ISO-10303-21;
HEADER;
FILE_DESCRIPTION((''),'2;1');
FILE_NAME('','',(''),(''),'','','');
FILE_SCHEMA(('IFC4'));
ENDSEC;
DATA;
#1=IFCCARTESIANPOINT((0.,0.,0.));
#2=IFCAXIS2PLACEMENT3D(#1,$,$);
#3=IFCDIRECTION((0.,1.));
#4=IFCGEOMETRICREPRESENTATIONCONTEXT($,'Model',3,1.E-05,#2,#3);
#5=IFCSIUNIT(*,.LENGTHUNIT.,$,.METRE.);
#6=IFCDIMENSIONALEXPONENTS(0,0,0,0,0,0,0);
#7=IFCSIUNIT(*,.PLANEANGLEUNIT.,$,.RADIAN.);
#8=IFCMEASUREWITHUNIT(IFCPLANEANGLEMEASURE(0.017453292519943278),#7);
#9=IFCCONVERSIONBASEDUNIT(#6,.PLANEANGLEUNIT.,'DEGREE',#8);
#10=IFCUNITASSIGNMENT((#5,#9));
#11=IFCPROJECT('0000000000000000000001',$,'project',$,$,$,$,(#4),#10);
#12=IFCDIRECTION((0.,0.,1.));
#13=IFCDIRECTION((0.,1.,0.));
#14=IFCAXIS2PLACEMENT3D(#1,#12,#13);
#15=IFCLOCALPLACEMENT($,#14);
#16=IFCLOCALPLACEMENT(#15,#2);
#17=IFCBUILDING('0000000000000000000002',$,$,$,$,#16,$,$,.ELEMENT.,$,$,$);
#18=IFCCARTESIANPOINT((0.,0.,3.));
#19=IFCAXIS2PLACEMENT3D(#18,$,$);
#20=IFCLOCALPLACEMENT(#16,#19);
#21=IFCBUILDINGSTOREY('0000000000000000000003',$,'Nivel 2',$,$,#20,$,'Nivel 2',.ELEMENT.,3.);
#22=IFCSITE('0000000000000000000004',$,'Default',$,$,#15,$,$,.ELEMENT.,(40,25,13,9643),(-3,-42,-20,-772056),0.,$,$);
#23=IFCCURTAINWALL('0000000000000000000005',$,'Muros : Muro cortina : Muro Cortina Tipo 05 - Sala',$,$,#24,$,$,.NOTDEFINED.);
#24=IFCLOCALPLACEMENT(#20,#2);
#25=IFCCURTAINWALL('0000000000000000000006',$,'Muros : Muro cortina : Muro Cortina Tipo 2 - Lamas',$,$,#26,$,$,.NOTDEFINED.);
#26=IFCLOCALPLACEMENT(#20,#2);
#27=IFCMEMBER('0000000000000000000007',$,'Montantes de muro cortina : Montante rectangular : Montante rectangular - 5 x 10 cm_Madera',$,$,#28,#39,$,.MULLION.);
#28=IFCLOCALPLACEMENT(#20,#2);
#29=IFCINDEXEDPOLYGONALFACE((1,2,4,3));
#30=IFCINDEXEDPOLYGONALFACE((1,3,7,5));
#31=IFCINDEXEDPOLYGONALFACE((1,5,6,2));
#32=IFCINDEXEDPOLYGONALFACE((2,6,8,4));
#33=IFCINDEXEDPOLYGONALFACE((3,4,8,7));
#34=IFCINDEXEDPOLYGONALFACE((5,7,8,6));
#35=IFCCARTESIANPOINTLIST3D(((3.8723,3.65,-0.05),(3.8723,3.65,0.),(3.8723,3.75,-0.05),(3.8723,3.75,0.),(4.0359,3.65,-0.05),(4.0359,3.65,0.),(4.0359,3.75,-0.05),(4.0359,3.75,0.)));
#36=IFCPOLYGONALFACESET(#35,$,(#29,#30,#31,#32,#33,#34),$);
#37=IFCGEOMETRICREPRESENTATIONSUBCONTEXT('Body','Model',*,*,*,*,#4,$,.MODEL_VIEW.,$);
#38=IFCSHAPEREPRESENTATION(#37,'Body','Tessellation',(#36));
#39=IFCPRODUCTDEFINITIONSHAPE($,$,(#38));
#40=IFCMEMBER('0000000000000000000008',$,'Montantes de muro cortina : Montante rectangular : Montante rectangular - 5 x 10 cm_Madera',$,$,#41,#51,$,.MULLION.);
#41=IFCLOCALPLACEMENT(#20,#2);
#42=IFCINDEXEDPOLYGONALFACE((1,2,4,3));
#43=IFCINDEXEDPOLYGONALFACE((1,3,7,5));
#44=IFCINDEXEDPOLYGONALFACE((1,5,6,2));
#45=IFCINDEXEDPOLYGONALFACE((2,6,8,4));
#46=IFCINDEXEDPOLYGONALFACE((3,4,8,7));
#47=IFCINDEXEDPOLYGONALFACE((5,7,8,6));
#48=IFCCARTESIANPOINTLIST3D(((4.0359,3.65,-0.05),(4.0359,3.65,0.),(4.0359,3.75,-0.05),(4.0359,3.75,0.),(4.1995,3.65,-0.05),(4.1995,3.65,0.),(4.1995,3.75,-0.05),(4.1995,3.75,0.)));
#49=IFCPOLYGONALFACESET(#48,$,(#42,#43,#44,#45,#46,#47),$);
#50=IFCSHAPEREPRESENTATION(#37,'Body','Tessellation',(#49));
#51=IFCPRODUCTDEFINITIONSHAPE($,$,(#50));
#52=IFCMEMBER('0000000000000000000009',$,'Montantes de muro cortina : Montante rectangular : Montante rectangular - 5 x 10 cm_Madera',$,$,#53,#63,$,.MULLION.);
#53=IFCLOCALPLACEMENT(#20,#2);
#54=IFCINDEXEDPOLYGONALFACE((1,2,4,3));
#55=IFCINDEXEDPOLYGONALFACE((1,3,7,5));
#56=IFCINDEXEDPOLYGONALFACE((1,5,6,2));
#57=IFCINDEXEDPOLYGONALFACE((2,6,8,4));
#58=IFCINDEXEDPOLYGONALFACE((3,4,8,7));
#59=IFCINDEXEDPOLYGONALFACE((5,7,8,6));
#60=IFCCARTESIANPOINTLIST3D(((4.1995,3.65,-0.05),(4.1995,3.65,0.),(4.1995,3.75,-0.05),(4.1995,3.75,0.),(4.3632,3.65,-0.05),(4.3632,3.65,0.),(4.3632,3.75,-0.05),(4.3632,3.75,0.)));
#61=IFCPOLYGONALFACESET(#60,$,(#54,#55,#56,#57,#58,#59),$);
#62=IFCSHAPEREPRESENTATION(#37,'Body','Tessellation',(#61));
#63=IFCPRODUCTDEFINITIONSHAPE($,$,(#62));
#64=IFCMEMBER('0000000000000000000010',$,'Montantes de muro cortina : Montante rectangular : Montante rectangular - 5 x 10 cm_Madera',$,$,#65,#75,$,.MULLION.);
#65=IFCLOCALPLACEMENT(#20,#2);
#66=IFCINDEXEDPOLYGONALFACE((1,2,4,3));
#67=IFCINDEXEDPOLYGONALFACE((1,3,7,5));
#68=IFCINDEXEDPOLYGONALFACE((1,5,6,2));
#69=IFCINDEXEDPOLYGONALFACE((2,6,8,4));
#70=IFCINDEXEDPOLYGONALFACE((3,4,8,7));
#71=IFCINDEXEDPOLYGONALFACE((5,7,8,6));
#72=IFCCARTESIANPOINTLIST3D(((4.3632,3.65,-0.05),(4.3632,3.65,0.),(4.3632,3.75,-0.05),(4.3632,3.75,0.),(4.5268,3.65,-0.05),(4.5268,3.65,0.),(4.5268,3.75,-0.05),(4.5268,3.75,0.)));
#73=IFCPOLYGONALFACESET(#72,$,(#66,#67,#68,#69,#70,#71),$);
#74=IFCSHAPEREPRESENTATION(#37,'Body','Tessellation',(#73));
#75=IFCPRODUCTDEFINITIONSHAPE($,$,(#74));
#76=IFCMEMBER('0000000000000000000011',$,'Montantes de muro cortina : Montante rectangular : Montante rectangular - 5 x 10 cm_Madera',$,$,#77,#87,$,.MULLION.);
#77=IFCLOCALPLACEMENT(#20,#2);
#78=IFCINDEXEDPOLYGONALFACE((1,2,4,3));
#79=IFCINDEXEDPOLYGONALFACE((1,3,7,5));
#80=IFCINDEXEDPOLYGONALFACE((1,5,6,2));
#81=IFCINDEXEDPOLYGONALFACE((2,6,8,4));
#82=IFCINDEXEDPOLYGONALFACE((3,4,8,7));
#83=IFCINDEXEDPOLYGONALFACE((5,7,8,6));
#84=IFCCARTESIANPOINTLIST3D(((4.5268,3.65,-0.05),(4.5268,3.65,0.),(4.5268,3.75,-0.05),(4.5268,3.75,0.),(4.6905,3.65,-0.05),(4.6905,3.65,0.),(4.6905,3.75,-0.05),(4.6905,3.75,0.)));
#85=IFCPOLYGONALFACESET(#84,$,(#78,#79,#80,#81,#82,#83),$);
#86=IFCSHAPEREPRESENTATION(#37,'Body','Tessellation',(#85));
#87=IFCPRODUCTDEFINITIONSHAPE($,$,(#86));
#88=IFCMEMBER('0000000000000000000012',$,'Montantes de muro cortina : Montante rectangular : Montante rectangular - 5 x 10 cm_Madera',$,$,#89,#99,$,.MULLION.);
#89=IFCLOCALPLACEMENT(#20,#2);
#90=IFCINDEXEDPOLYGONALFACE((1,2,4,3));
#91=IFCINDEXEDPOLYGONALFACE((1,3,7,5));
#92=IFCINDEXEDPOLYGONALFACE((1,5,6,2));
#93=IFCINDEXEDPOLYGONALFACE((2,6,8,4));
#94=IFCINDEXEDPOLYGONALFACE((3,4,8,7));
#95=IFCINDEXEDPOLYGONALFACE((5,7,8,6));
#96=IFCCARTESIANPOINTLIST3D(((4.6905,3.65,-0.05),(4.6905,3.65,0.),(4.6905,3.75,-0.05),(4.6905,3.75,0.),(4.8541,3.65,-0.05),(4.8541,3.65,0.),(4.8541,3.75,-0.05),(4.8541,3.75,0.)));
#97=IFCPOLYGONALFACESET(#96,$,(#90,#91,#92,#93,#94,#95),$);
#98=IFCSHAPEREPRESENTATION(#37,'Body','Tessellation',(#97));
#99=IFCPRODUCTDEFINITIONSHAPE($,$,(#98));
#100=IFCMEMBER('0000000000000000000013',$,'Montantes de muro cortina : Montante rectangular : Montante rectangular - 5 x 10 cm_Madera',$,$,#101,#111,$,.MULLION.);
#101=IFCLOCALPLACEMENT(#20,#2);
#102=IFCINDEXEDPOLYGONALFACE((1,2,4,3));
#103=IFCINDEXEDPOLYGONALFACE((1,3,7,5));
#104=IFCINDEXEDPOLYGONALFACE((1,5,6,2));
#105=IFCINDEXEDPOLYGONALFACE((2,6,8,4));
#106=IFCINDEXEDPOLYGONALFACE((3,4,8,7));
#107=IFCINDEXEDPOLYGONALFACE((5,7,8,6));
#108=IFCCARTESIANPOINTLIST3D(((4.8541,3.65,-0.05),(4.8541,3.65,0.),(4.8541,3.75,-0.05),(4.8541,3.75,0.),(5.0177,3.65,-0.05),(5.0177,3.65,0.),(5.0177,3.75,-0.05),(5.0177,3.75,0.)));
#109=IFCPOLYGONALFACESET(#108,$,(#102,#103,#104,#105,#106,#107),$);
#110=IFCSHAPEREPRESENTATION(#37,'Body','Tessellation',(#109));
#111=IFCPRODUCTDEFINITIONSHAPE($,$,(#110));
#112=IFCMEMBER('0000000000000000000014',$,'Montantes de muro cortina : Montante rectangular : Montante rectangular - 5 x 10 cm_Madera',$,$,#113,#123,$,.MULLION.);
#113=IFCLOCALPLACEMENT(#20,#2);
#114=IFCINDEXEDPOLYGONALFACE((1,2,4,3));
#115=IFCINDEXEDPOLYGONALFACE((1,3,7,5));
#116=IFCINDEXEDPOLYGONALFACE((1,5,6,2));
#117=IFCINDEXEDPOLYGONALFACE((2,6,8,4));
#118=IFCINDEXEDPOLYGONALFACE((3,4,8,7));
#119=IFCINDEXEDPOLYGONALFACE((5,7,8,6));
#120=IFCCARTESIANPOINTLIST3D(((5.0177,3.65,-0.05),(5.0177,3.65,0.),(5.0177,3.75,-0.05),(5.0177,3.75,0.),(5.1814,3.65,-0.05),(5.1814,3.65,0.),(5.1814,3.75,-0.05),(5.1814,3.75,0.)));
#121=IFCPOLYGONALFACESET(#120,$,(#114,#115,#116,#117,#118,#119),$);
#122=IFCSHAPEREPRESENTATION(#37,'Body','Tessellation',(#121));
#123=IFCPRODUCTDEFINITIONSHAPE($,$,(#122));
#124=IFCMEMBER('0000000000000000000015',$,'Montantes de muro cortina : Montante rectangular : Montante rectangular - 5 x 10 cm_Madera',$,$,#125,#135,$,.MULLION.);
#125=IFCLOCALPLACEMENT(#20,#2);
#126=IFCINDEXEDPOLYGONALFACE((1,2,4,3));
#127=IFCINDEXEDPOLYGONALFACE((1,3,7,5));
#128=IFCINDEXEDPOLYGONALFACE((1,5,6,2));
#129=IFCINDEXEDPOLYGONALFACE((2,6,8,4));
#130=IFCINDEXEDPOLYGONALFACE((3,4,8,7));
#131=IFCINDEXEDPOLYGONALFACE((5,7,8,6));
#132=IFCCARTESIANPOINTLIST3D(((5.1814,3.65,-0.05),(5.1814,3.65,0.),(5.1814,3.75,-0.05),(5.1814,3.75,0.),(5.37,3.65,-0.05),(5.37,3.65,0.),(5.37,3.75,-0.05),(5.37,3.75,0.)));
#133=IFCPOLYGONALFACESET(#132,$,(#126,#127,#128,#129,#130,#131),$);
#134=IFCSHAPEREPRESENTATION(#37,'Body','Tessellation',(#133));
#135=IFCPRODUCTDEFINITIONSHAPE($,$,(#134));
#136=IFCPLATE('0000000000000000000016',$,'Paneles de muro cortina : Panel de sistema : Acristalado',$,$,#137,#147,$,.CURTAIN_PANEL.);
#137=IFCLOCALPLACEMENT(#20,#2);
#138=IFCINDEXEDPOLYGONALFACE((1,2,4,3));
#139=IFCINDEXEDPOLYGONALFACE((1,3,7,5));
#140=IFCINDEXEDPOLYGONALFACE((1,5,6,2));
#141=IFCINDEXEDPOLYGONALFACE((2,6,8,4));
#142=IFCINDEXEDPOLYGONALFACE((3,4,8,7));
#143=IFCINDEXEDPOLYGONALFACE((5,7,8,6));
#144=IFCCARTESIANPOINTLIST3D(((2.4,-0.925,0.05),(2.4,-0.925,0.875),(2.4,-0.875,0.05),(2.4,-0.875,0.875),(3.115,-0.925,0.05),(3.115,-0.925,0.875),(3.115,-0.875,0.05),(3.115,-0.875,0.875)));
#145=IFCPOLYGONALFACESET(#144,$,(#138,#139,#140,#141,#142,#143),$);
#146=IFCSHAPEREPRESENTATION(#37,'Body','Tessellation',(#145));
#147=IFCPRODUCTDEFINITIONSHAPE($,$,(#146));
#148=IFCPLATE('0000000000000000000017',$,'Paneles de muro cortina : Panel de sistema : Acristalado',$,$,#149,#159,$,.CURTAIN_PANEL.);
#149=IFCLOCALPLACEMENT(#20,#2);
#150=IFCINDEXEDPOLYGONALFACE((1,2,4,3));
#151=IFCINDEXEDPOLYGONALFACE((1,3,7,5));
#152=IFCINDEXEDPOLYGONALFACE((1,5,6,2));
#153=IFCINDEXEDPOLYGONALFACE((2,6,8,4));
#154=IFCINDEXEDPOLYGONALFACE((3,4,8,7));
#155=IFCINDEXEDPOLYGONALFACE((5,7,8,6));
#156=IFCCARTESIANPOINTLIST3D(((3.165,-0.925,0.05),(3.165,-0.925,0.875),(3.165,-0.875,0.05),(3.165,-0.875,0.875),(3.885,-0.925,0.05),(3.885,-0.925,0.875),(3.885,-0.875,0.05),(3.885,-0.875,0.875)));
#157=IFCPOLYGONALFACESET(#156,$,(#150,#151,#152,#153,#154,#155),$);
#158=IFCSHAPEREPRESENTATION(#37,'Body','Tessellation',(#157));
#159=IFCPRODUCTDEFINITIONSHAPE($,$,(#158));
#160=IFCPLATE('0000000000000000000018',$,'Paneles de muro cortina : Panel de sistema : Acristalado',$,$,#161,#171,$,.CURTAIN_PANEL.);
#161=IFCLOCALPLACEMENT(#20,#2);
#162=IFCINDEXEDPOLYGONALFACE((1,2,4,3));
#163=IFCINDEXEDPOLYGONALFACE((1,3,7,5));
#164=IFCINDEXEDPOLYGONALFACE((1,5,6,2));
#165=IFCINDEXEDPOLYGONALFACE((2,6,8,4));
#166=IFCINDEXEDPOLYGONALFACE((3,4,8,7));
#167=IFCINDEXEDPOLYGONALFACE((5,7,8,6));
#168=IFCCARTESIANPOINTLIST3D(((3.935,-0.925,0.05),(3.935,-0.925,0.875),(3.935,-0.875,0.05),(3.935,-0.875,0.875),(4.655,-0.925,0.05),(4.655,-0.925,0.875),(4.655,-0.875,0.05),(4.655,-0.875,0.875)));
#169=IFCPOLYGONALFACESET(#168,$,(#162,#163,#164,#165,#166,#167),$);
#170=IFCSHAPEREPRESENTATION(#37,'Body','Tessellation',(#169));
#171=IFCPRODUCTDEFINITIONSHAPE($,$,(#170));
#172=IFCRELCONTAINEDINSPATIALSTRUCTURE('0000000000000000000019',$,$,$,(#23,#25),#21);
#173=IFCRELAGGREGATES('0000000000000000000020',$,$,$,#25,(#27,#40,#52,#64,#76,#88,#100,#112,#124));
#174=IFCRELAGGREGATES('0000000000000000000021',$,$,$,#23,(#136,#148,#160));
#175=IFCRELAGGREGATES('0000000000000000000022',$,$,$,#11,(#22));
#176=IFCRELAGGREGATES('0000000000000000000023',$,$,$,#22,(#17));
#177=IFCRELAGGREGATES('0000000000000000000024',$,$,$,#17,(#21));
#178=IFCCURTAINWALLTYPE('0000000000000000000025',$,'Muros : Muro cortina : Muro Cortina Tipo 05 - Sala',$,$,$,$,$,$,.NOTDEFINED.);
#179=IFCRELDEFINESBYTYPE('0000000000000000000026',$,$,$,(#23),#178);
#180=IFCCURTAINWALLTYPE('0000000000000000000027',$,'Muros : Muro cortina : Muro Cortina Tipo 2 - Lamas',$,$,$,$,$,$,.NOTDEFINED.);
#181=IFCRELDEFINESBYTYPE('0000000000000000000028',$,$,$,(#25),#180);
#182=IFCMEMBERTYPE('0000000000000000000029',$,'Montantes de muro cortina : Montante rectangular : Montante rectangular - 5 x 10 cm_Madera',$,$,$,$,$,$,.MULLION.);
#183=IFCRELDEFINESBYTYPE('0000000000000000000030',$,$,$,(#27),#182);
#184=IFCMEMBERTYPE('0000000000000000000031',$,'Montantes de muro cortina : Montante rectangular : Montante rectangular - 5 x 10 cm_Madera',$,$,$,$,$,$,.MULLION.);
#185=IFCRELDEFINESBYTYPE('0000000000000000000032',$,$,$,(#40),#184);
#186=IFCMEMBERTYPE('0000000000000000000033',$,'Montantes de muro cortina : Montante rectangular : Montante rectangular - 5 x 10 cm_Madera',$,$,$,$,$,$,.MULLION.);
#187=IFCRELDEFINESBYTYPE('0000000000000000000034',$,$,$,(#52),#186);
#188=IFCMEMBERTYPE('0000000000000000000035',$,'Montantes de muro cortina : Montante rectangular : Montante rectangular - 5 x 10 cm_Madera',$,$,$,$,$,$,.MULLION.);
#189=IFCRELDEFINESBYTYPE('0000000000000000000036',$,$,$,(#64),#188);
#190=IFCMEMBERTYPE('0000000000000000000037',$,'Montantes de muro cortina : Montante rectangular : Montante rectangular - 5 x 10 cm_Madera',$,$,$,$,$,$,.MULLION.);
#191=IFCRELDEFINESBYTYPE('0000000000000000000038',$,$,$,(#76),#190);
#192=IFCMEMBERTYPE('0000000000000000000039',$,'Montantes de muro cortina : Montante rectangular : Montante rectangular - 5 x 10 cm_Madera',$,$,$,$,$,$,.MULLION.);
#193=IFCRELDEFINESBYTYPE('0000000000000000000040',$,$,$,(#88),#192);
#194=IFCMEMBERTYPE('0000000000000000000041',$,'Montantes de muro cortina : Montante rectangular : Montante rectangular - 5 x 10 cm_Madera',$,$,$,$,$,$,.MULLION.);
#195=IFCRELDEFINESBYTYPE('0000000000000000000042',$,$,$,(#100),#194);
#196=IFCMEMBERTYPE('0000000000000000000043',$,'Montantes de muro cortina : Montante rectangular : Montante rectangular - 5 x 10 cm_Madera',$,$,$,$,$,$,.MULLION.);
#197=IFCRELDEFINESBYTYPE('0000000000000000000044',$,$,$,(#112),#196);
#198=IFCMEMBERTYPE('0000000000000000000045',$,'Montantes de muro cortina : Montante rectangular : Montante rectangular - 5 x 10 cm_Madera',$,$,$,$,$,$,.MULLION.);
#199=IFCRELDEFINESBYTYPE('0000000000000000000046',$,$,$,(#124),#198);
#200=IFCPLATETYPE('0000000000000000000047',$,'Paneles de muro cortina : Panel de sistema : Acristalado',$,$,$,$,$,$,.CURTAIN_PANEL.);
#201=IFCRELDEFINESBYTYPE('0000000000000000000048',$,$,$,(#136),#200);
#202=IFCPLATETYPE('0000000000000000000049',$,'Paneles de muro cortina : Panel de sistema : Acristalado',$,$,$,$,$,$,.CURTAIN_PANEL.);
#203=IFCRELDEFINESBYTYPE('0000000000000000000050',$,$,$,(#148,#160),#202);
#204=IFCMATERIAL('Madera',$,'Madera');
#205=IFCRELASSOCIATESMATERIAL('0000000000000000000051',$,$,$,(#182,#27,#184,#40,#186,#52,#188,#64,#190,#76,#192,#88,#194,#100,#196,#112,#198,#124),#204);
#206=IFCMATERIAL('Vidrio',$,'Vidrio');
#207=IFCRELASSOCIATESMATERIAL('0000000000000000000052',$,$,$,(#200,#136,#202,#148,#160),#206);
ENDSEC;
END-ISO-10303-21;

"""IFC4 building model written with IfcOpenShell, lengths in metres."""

from ifc_helpers import new_model, entity, si_unit, converted_unit, direction, frame, origin, place, context, subcontext, project, spatial, indexed_curve, outline, extrude, source, transform, mapped, material, type_object, type_shapes, element, aggregate, save


model = new_model("IFC4")

# Units and contexts
model_context = context("Model", 3, precision=1e-05, world=origin(), true_north=direction((0.0, 1.0)))
body_context = subcontext(model_context, "Body", "Model", "MODEL_VIEW")
ifc_project = project(units=[si_unit("LENGTHUNIT", "METRE"), converted_unit("PLANEANGLEUNIT", "DEGREE", entity("IfcPlaneAngleMeasure", 0.017453292519943278), si_unit("PLANEANGLEUNIT", "RADIAN"), dimensions=[0, 0, 0, 0, 0, 0, 0])], contexts=[model_context])

# Site, building, storey
site_placement = place(None, frame((0.0, 0.0, 0.0), z_axis=(0.0, 0.0, 1.0), x_axis=(0.0, 1.0, 0.0)))
site = spatial("IfcSite", under=ifc_project, at=site_placement, Name="Default", CompositionType="ELEMENT", RefLatitude=(40, 25, 13, 9643), RefLongitude=(-3, -42, -20, -772056), RefElevation=0.0)
building_placement = place(site_placement, origin())
building = spatial("IfcBuilding", under=site, at=building_placement, CompositionType="ELEMENT")
storey_placement = place(building_placement, frame((0.0, 0.0, 3.0)))
storey = spatial("IfcBuildingStorey", under=building, at=storey_placement, Name="Nivel 2", LongName="Nivel 2", CompositionType="ELEMENT", Elevation=3.0)

# Curtain walls, members
curtain_wall_type_1 = type_object("IfcCurtainWallType", Name="Muros : Muro cortina : Muro Cortina Tipo 05 - Sala", PredefinedType="NOTDEFINED")
curtain_wall_1_placement = place(storey_placement, frame((0.0, 0.0, -3.0)))
curtain_wall_1 = element("IfcCurtainWall", 1, at=curtain_wall_1_placement, inside=storey, type_object=curtain_wall_type_1, Name="Muros : Muro cortina : Muro Cortina Tipo 05 - Sala", PredefinedType="NOTDEFINED")
curtain_wall_type_2 = type_object("IfcCurtainWallType", Name="Muros : Muro cortina : Muro Cortina Tipo 2 - Lamas", PredefinedType="NOTDEFINED")
curtain_wall_2_placement = place(storey_placement, frame((0.0, 0.0, -3.0)))
curtain_wall_2 = element("IfcCurtainWall", 2, at=curtain_wall_2_placement, inside=storey, type_object=curtain_wall_type_2, Name="Muros : Muro cortina : Muro Cortina Tipo 2 - Lamas", PredefinedType="NOTDEFINED")
ifc_material_1 = material(Name="Madera", Category="Madera")
member_type_1 = type_object("IfcMemberType", Name="Montantes de muro cortina : Montante rectangular : Montante rectangular - 5 x 10 cm_Madera", PredefinedType="MULLION", material=ifc_material_1)
shared_shape_1 = source(origin(), body_context, "Body", "SweptSolid", [
    extrude(outline(indexed_curve([(-0.0818, -0.05), (0.0818, -0.05), (0.0818, 0.05), (-0.0818, 0.05), (-0.0818, -0.05)], self_intersect=False)), frame((3.9541, 3.7, 2.95), z_axis=(0.0, 0.0, 1.0), x_axis=(-1.0, 0.0, 0.0)), (0.0, 0.0, 1.0), 0.05),
])
type_shapes(member_type_1, [shared_shape_1])
member_1_placement = place(curtain_wall_2_placement, origin())
member_1 = element("IfcMember", 3, at=member_1_placement, type_object=member_type_1, material=ifc_material_1, Name="Montantes de muro cortina : Montante rectangular : Montante rectangular - 5 x 10 cm_Madera", PredefinedType="MULLION", context=body_context, shape_type="MappedRepresentation", body=[
    mapped(shared_shape_1, transform((0.0, 0.0, 0.0), scale=1.0)),
])
member_type_2 = type_object("IfcMemberType", Name="Montantes de muro cortina : Montante rectangular : Montante rectangular - 5 x 10 cm_Madera", PredefinedType="MULLION", material=ifc_material_1)
shared_shape_2 = source(origin(), body_context, "Body", "SweptSolid", [
    extrude(outline(indexed_curve([(-0.0818, -0.05), (0.0818, -0.05), (0.0818, 0.05), (-0.0818, 0.05), (-0.0818, -0.05)], self_intersect=False)), frame((4.1177, 3.7, 2.95), z_axis=(0.0, 0.0, 1.0), x_axis=(-1.0, 0.0, 0.0)), (0.0, 0.0, 1.0), 0.05),
])
type_shapes(member_type_2, [shared_shape_2])
member_2_placement = place(curtain_wall_2_placement, origin())
member_2 = element("IfcMember", 4, at=member_2_placement, type_object=member_type_2, material=ifc_material_1, Name="Montantes de muro cortina : Montante rectangular : Montante rectangular - 5 x 10 cm_Madera", PredefinedType="MULLION", context=body_context, shape_type="MappedRepresentation", body=[
    mapped(shared_shape_2, transform((0.0, 0.0, 0.0), scale=1.0)),
])
member_type_3 = type_object("IfcMemberType", Name="Montantes de muro cortina : Montante rectangular : Montante rectangular - 5 x 10 cm_Madera", PredefinedType="MULLION", material=ifc_material_1)
shared_shape_3 = source(origin(), body_context, "Body", "SweptSolid", [
    extrude(outline(indexed_curve([(-0.0818, -0.05), (0.0818, -0.05), (0.0818, 0.05), (-0.0818, 0.05), (-0.0818, -0.05)], self_intersect=False)), frame((4.2814, 3.7, 2.95), z_axis=(0.0, 0.0, 1.0), x_axis=(-1.0, 0.0, 0.0)), (0.0, 0.0, 1.0), 0.05),
])
type_shapes(member_type_3, [shared_shape_3])
member_3_placement = place(curtain_wall_2_placement, origin())
member_3 = element("IfcMember", 5, at=member_3_placement, type_object=member_type_3, material=ifc_material_1, Name="Montantes de muro cortina : Montante rectangular : Montante rectangular - 5 x 10 cm_Madera", PredefinedType="MULLION", context=body_context, shape_type="MappedRepresentation", body=[
    mapped(shared_shape_3, transform((0.0, 0.0, 0.0), scale=1.0)),
])
member_type_4 = type_object("IfcMemberType", Name="Montantes de muro cortina : Montante rectangular : Montante rectangular - 5 x 10 cm_Madera", PredefinedType="MULLION", material=ifc_material_1)
shared_shape_4 = source(origin(), body_context, "Body", "SweptSolid", [
    extrude(outline(indexed_curve([(-0.0818, -0.05), (0.0818, -0.05), (0.0818, 0.05), (-0.0818, 0.05), (-0.0818, -0.05)], self_intersect=False)), frame((4.445, 3.7, 2.95), z_axis=(0.0, 0.0, 1.0), x_axis=(-1.0, 0.0, 0.0)), (0.0, 0.0, 1.0), 0.05),
])
type_shapes(member_type_4, [shared_shape_4])
member_4_placement = place(curtain_wall_2_placement, origin())
member_4 = element("IfcMember", 6, at=member_4_placement, type_object=member_type_4, material=ifc_material_1, Name="Montantes de muro cortina : Montante rectangular : Montante rectangular - 5 x 10 cm_Madera", PredefinedType="MULLION", context=body_context, shape_type="MappedRepresentation", body=[
    mapped(shared_shape_4, transform((0.0, 0.0, 0.0), scale=1.0)),
])
member_type_5 = type_object("IfcMemberType", Name="Montantes de muro cortina : Montante rectangular : Montante rectangular - 5 x 10 cm_Madera", PredefinedType="MULLION", material=ifc_material_1)
shared_shape_5 = source(origin(), body_context, "Body", "SweptSolid", [
    extrude(outline(indexed_curve([(-0.0818, -0.05), (0.0818, -0.05), (0.0818, 0.05), (-0.0818, 0.05), (-0.0818, -0.05)], self_intersect=False)), frame((4.6086, 3.7, 2.95), z_axis=(0.0, 0.0, 1.0), x_axis=(-1.0, 0.0, 0.0)), (0.0, 0.0, 1.0), 0.05),
])
type_shapes(member_type_5, [shared_shape_5])
member_5_placement = place(curtain_wall_2_placement, origin())
member_5 = element("IfcMember", 7, at=member_5_placement, type_object=member_type_5, material=ifc_material_1, Name="Montantes de muro cortina : Montante rectangular : Montante rectangular - 5 x 10 cm_Madera", PredefinedType="MULLION", context=body_context, shape_type="MappedRepresentation", body=[
    mapped(shared_shape_5, transform((0.0, 0.0, 0.0), scale=1.0)),
])
member_type_6 = type_object("IfcMemberType", Name="Montantes de muro cortina : Montante rectangular : Montante rectangular - 5 x 10 cm_Madera", PredefinedType="MULLION", material=ifc_material_1)
shared_shape_6 = source(origin(), body_context, "Body", "SweptSolid", [
    extrude(outline(indexed_curve([(-0.0818, -0.05), (0.0818, -0.05), (0.0818, 0.05), (-0.0818, 0.05), (-0.0818, -0.05)], self_intersect=False)), frame((4.7723, 3.7, 2.95), z_axis=(0.0, 0.0, 1.0), x_axis=(-1.0, 0.0, 0.0)), (0.0, 0.0, 1.0), 0.05),
])
type_shapes(member_type_6, [shared_shape_6])
member_6_placement = place(curtain_wall_2_placement, origin())
member_6 = element("IfcMember", 8, at=member_6_placement, type_object=member_type_6, material=ifc_material_1, Name="Montantes de muro cortina : Montante rectangular : Montante rectangular - 5 x 10 cm_Madera", PredefinedType="MULLION", context=body_context, shape_type="MappedRepresentation", body=[
    mapped(shared_shape_6, transform((0.0, 0.0, 0.0), scale=1.0)),
])
member_type_7 = type_object("IfcMemberType", Name="Montantes de muro cortina : Montante rectangular : Montante rectangular - 5 x 10 cm_Madera", PredefinedType="MULLION", material=ifc_material_1)
shared_shape_7 = source(origin(), body_context, "Body", "SweptSolid", [
    extrude(outline(indexed_curve([(-0.0818, -0.05), (0.0818, -0.05), (0.0818, 0.05), (-0.0818, 0.05), (-0.0818, -0.05)], self_intersect=False)), frame((4.9359, 3.7, 2.95), z_axis=(0.0, 0.0, 1.0), x_axis=(-1.0, 0.0, 0.0)), (0.0, 0.0, 1.0), 0.05),
])
type_shapes(member_type_7, [shared_shape_7])
member_7_placement = place(curtain_wall_2_placement, origin())
member_7 = element("IfcMember", 9, at=member_7_placement, type_object=member_type_7, material=ifc_material_1, Name="Montantes de muro cortina : Montante rectangular : Montante rectangular - 5 x 10 cm_Madera", PredefinedType="MULLION", context=body_context, shape_type="MappedRepresentation", body=[
    mapped(shared_shape_7, transform((0.0, 0.0, 0.0), scale=1.0)),
])
member_type_8 = type_object("IfcMemberType", Name="Montantes de muro cortina : Montante rectangular : Montante rectangular - 5 x 10 cm_Madera", PredefinedType="MULLION", material=ifc_material_1)
shared_shape_8 = source(origin(), body_context, "Body", "SweptSolid", [
    extrude(outline(indexed_curve([(-0.0818, -0.05), (0.0818, -0.05), (0.0818, 0.05), (-0.0818, 0.05), (-0.0818, -0.05)], self_intersect=False)), frame((5.0995, 3.7, 2.95), z_axis=(0.0, 0.0, 1.0), x_axis=(-1.0, 0.0, 0.0)), (0.0, 0.0, 1.0), 0.05),
])
type_shapes(member_type_8, [shared_shape_8])
member_8_placement = place(curtain_wall_2_placement, origin())
member_8 = element("IfcMember", 10, at=member_8_placement, type_object=member_type_8, material=ifc_material_1, Name="Montantes de muro cortina : Montante rectangular : Montante rectangular - 5 x 10 cm_Madera", PredefinedType="MULLION", context=body_context, shape_type="MappedRepresentation", body=[
    mapped(shared_shape_8, transform((0.0, 0.0, 0.0), scale=1.0)),
])
member_type_9 = type_object("IfcMemberType", Name="Montantes de muro cortina : Montante rectangular : Montante rectangular - 5 x 10 cm_Madera", PredefinedType="MULLION", material=ifc_material_1)
shared_shape_9 = source(origin(), body_context, "Body", "SweptSolid", [
    extrude(outline(indexed_curve([(-0.0943, -0.05), (0.0943, -0.05), (0.0943, 0.05), (-0.0943, 0.05), (-0.0943, -0.05)], self_intersect=False)), frame((5.2757, 3.7, 2.95), z_axis=(0.0, 0.0, 1.0), x_axis=(-1.0, 0.0, 0.0)), (0.0, 0.0, 1.0), 0.05),
])
type_shapes(member_type_9, [shared_shape_9])
member_9_placement = place(curtain_wall_2_placement, origin())
member_9 = element("IfcMember", 11, at=member_9_placement, type_object=member_type_9, material=ifc_material_1, Name="Montantes de muro cortina : Montante rectangular : Montante rectangular - 5 x 10 cm_Madera", PredefinedType="MULLION", context=body_context, shape_type="MappedRepresentation", body=[
    mapped(shared_shape_9, transform((0.0, 0.0, 0.0), scale=1.0)),
])
aggregate(curtain_wall_2, [member_1, member_2, member_3, member_4, member_5, member_6, member_7, member_8, member_9])

# Plates
ifc_material_2 = material(Name="Vidrio", Category="Vidrio")
plate_type_1 = type_object("IfcPlateType", Name="Paneles de muro cortina : Panel de sistema : Acristalado", PredefinedType="CURTAIN_PANEL", material=ifc_material_2)
shared_shape_10 = source(origin(), body_context, "Body", "SweptSolid", [
    extrude(outline(indexed_curve([(-0.025, -0.3575), (0.025, -0.3575), (0.025, 0.3575), (-0.025, 0.3575), (-0.025, -0.3575)], self_intersect=False)), frame((0.0, 0.0, 0.0), z_axis=(0.0, 0.0, 1.0), x_axis=(0.0, 1.0, 0.0)), (0.0, 0.0, 1.0), 0.825),
])
type_shapes(plate_type_1, [shared_shape_10])
plate_1_placement = place(curtain_wall_1_placement, frame((2.7575, -0.9, 3.05)))
plate_1 = element("IfcPlate", 12, at=plate_1_placement, type_object=plate_type_1, material=ifc_material_2, Name="Paneles de muro cortina : Panel de sistema : Acristalado", PredefinedType="CURTAIN_PANEL", context=body_context, shape_type="MappedRepresentation", body=[
    mapped(shared_shape_10, transform((0.0, 0.0, 0.0), scale=1.0)),
])
plate_type_2 = type_object("IfcPlateType", Name="Paneles de muro cortina : Panel de sistema : Acristalado", PredefinedType="CURTAIN_PANEL", material=ifc_material_2)
shared_shape_11 = source(origin(), body_context, "Body", "SweptSolid", [
    extrude(outline(indexed_curve([(-0.025, -0.36), (0.025, -0.36), (0.025, 0.36), (-0.025, 0.36), (-0.025, -0.36)], self_intersect=False)), frame((0.0, 0.0, 0.0), z_axis=(0.0, 0.0, 1.0), x_axis=(0.0, 1.0, 0.0)), (0.0, 0.0, 1.0), 0.825),
])
type_shapes(plate_type_2, [shared_shape_11])
plate_2_placement = place(curtain_wall_1_placement, frame((3.525, -0.9, 3.05)))
plate_2 = element("IfcPlate", 13, at=plate_2_placement, type_object=plate_type_2, material=ifc_material_2, Name="Paneles de muro cortina : Panel de sistema : Acristalado", PredefinedType="CURTAIN_PANEL", context=body_context, shape_type="MappedRepresentation", body=[
    mapped(shared_shape_11, transform((0.0, 0.0, 0.0), scale=1.0)),
])
plate_3_placement = place(curtain_wall_1_placement, frame((4.295, -0.9, 3.05)))
plate_3 = element("IfcPlate", 14, at=plate_3_placement, type_object=plate_type_2, material=ifc_material_2, Name="Paneles de muro cortina : Panel de sistema : Acristalado", PredefinedType="CURTAIN_PANEL", context=body_context, shape_type="MappedRepresentation", body=[
    mapped(shared_shape_11, transform((0.0, 0.0, 0.0), scale=1.0)),
])
aggregate(curtain_wall_1, [plate_1, plate_2, plate_3])

save(model, "model.ifc")
